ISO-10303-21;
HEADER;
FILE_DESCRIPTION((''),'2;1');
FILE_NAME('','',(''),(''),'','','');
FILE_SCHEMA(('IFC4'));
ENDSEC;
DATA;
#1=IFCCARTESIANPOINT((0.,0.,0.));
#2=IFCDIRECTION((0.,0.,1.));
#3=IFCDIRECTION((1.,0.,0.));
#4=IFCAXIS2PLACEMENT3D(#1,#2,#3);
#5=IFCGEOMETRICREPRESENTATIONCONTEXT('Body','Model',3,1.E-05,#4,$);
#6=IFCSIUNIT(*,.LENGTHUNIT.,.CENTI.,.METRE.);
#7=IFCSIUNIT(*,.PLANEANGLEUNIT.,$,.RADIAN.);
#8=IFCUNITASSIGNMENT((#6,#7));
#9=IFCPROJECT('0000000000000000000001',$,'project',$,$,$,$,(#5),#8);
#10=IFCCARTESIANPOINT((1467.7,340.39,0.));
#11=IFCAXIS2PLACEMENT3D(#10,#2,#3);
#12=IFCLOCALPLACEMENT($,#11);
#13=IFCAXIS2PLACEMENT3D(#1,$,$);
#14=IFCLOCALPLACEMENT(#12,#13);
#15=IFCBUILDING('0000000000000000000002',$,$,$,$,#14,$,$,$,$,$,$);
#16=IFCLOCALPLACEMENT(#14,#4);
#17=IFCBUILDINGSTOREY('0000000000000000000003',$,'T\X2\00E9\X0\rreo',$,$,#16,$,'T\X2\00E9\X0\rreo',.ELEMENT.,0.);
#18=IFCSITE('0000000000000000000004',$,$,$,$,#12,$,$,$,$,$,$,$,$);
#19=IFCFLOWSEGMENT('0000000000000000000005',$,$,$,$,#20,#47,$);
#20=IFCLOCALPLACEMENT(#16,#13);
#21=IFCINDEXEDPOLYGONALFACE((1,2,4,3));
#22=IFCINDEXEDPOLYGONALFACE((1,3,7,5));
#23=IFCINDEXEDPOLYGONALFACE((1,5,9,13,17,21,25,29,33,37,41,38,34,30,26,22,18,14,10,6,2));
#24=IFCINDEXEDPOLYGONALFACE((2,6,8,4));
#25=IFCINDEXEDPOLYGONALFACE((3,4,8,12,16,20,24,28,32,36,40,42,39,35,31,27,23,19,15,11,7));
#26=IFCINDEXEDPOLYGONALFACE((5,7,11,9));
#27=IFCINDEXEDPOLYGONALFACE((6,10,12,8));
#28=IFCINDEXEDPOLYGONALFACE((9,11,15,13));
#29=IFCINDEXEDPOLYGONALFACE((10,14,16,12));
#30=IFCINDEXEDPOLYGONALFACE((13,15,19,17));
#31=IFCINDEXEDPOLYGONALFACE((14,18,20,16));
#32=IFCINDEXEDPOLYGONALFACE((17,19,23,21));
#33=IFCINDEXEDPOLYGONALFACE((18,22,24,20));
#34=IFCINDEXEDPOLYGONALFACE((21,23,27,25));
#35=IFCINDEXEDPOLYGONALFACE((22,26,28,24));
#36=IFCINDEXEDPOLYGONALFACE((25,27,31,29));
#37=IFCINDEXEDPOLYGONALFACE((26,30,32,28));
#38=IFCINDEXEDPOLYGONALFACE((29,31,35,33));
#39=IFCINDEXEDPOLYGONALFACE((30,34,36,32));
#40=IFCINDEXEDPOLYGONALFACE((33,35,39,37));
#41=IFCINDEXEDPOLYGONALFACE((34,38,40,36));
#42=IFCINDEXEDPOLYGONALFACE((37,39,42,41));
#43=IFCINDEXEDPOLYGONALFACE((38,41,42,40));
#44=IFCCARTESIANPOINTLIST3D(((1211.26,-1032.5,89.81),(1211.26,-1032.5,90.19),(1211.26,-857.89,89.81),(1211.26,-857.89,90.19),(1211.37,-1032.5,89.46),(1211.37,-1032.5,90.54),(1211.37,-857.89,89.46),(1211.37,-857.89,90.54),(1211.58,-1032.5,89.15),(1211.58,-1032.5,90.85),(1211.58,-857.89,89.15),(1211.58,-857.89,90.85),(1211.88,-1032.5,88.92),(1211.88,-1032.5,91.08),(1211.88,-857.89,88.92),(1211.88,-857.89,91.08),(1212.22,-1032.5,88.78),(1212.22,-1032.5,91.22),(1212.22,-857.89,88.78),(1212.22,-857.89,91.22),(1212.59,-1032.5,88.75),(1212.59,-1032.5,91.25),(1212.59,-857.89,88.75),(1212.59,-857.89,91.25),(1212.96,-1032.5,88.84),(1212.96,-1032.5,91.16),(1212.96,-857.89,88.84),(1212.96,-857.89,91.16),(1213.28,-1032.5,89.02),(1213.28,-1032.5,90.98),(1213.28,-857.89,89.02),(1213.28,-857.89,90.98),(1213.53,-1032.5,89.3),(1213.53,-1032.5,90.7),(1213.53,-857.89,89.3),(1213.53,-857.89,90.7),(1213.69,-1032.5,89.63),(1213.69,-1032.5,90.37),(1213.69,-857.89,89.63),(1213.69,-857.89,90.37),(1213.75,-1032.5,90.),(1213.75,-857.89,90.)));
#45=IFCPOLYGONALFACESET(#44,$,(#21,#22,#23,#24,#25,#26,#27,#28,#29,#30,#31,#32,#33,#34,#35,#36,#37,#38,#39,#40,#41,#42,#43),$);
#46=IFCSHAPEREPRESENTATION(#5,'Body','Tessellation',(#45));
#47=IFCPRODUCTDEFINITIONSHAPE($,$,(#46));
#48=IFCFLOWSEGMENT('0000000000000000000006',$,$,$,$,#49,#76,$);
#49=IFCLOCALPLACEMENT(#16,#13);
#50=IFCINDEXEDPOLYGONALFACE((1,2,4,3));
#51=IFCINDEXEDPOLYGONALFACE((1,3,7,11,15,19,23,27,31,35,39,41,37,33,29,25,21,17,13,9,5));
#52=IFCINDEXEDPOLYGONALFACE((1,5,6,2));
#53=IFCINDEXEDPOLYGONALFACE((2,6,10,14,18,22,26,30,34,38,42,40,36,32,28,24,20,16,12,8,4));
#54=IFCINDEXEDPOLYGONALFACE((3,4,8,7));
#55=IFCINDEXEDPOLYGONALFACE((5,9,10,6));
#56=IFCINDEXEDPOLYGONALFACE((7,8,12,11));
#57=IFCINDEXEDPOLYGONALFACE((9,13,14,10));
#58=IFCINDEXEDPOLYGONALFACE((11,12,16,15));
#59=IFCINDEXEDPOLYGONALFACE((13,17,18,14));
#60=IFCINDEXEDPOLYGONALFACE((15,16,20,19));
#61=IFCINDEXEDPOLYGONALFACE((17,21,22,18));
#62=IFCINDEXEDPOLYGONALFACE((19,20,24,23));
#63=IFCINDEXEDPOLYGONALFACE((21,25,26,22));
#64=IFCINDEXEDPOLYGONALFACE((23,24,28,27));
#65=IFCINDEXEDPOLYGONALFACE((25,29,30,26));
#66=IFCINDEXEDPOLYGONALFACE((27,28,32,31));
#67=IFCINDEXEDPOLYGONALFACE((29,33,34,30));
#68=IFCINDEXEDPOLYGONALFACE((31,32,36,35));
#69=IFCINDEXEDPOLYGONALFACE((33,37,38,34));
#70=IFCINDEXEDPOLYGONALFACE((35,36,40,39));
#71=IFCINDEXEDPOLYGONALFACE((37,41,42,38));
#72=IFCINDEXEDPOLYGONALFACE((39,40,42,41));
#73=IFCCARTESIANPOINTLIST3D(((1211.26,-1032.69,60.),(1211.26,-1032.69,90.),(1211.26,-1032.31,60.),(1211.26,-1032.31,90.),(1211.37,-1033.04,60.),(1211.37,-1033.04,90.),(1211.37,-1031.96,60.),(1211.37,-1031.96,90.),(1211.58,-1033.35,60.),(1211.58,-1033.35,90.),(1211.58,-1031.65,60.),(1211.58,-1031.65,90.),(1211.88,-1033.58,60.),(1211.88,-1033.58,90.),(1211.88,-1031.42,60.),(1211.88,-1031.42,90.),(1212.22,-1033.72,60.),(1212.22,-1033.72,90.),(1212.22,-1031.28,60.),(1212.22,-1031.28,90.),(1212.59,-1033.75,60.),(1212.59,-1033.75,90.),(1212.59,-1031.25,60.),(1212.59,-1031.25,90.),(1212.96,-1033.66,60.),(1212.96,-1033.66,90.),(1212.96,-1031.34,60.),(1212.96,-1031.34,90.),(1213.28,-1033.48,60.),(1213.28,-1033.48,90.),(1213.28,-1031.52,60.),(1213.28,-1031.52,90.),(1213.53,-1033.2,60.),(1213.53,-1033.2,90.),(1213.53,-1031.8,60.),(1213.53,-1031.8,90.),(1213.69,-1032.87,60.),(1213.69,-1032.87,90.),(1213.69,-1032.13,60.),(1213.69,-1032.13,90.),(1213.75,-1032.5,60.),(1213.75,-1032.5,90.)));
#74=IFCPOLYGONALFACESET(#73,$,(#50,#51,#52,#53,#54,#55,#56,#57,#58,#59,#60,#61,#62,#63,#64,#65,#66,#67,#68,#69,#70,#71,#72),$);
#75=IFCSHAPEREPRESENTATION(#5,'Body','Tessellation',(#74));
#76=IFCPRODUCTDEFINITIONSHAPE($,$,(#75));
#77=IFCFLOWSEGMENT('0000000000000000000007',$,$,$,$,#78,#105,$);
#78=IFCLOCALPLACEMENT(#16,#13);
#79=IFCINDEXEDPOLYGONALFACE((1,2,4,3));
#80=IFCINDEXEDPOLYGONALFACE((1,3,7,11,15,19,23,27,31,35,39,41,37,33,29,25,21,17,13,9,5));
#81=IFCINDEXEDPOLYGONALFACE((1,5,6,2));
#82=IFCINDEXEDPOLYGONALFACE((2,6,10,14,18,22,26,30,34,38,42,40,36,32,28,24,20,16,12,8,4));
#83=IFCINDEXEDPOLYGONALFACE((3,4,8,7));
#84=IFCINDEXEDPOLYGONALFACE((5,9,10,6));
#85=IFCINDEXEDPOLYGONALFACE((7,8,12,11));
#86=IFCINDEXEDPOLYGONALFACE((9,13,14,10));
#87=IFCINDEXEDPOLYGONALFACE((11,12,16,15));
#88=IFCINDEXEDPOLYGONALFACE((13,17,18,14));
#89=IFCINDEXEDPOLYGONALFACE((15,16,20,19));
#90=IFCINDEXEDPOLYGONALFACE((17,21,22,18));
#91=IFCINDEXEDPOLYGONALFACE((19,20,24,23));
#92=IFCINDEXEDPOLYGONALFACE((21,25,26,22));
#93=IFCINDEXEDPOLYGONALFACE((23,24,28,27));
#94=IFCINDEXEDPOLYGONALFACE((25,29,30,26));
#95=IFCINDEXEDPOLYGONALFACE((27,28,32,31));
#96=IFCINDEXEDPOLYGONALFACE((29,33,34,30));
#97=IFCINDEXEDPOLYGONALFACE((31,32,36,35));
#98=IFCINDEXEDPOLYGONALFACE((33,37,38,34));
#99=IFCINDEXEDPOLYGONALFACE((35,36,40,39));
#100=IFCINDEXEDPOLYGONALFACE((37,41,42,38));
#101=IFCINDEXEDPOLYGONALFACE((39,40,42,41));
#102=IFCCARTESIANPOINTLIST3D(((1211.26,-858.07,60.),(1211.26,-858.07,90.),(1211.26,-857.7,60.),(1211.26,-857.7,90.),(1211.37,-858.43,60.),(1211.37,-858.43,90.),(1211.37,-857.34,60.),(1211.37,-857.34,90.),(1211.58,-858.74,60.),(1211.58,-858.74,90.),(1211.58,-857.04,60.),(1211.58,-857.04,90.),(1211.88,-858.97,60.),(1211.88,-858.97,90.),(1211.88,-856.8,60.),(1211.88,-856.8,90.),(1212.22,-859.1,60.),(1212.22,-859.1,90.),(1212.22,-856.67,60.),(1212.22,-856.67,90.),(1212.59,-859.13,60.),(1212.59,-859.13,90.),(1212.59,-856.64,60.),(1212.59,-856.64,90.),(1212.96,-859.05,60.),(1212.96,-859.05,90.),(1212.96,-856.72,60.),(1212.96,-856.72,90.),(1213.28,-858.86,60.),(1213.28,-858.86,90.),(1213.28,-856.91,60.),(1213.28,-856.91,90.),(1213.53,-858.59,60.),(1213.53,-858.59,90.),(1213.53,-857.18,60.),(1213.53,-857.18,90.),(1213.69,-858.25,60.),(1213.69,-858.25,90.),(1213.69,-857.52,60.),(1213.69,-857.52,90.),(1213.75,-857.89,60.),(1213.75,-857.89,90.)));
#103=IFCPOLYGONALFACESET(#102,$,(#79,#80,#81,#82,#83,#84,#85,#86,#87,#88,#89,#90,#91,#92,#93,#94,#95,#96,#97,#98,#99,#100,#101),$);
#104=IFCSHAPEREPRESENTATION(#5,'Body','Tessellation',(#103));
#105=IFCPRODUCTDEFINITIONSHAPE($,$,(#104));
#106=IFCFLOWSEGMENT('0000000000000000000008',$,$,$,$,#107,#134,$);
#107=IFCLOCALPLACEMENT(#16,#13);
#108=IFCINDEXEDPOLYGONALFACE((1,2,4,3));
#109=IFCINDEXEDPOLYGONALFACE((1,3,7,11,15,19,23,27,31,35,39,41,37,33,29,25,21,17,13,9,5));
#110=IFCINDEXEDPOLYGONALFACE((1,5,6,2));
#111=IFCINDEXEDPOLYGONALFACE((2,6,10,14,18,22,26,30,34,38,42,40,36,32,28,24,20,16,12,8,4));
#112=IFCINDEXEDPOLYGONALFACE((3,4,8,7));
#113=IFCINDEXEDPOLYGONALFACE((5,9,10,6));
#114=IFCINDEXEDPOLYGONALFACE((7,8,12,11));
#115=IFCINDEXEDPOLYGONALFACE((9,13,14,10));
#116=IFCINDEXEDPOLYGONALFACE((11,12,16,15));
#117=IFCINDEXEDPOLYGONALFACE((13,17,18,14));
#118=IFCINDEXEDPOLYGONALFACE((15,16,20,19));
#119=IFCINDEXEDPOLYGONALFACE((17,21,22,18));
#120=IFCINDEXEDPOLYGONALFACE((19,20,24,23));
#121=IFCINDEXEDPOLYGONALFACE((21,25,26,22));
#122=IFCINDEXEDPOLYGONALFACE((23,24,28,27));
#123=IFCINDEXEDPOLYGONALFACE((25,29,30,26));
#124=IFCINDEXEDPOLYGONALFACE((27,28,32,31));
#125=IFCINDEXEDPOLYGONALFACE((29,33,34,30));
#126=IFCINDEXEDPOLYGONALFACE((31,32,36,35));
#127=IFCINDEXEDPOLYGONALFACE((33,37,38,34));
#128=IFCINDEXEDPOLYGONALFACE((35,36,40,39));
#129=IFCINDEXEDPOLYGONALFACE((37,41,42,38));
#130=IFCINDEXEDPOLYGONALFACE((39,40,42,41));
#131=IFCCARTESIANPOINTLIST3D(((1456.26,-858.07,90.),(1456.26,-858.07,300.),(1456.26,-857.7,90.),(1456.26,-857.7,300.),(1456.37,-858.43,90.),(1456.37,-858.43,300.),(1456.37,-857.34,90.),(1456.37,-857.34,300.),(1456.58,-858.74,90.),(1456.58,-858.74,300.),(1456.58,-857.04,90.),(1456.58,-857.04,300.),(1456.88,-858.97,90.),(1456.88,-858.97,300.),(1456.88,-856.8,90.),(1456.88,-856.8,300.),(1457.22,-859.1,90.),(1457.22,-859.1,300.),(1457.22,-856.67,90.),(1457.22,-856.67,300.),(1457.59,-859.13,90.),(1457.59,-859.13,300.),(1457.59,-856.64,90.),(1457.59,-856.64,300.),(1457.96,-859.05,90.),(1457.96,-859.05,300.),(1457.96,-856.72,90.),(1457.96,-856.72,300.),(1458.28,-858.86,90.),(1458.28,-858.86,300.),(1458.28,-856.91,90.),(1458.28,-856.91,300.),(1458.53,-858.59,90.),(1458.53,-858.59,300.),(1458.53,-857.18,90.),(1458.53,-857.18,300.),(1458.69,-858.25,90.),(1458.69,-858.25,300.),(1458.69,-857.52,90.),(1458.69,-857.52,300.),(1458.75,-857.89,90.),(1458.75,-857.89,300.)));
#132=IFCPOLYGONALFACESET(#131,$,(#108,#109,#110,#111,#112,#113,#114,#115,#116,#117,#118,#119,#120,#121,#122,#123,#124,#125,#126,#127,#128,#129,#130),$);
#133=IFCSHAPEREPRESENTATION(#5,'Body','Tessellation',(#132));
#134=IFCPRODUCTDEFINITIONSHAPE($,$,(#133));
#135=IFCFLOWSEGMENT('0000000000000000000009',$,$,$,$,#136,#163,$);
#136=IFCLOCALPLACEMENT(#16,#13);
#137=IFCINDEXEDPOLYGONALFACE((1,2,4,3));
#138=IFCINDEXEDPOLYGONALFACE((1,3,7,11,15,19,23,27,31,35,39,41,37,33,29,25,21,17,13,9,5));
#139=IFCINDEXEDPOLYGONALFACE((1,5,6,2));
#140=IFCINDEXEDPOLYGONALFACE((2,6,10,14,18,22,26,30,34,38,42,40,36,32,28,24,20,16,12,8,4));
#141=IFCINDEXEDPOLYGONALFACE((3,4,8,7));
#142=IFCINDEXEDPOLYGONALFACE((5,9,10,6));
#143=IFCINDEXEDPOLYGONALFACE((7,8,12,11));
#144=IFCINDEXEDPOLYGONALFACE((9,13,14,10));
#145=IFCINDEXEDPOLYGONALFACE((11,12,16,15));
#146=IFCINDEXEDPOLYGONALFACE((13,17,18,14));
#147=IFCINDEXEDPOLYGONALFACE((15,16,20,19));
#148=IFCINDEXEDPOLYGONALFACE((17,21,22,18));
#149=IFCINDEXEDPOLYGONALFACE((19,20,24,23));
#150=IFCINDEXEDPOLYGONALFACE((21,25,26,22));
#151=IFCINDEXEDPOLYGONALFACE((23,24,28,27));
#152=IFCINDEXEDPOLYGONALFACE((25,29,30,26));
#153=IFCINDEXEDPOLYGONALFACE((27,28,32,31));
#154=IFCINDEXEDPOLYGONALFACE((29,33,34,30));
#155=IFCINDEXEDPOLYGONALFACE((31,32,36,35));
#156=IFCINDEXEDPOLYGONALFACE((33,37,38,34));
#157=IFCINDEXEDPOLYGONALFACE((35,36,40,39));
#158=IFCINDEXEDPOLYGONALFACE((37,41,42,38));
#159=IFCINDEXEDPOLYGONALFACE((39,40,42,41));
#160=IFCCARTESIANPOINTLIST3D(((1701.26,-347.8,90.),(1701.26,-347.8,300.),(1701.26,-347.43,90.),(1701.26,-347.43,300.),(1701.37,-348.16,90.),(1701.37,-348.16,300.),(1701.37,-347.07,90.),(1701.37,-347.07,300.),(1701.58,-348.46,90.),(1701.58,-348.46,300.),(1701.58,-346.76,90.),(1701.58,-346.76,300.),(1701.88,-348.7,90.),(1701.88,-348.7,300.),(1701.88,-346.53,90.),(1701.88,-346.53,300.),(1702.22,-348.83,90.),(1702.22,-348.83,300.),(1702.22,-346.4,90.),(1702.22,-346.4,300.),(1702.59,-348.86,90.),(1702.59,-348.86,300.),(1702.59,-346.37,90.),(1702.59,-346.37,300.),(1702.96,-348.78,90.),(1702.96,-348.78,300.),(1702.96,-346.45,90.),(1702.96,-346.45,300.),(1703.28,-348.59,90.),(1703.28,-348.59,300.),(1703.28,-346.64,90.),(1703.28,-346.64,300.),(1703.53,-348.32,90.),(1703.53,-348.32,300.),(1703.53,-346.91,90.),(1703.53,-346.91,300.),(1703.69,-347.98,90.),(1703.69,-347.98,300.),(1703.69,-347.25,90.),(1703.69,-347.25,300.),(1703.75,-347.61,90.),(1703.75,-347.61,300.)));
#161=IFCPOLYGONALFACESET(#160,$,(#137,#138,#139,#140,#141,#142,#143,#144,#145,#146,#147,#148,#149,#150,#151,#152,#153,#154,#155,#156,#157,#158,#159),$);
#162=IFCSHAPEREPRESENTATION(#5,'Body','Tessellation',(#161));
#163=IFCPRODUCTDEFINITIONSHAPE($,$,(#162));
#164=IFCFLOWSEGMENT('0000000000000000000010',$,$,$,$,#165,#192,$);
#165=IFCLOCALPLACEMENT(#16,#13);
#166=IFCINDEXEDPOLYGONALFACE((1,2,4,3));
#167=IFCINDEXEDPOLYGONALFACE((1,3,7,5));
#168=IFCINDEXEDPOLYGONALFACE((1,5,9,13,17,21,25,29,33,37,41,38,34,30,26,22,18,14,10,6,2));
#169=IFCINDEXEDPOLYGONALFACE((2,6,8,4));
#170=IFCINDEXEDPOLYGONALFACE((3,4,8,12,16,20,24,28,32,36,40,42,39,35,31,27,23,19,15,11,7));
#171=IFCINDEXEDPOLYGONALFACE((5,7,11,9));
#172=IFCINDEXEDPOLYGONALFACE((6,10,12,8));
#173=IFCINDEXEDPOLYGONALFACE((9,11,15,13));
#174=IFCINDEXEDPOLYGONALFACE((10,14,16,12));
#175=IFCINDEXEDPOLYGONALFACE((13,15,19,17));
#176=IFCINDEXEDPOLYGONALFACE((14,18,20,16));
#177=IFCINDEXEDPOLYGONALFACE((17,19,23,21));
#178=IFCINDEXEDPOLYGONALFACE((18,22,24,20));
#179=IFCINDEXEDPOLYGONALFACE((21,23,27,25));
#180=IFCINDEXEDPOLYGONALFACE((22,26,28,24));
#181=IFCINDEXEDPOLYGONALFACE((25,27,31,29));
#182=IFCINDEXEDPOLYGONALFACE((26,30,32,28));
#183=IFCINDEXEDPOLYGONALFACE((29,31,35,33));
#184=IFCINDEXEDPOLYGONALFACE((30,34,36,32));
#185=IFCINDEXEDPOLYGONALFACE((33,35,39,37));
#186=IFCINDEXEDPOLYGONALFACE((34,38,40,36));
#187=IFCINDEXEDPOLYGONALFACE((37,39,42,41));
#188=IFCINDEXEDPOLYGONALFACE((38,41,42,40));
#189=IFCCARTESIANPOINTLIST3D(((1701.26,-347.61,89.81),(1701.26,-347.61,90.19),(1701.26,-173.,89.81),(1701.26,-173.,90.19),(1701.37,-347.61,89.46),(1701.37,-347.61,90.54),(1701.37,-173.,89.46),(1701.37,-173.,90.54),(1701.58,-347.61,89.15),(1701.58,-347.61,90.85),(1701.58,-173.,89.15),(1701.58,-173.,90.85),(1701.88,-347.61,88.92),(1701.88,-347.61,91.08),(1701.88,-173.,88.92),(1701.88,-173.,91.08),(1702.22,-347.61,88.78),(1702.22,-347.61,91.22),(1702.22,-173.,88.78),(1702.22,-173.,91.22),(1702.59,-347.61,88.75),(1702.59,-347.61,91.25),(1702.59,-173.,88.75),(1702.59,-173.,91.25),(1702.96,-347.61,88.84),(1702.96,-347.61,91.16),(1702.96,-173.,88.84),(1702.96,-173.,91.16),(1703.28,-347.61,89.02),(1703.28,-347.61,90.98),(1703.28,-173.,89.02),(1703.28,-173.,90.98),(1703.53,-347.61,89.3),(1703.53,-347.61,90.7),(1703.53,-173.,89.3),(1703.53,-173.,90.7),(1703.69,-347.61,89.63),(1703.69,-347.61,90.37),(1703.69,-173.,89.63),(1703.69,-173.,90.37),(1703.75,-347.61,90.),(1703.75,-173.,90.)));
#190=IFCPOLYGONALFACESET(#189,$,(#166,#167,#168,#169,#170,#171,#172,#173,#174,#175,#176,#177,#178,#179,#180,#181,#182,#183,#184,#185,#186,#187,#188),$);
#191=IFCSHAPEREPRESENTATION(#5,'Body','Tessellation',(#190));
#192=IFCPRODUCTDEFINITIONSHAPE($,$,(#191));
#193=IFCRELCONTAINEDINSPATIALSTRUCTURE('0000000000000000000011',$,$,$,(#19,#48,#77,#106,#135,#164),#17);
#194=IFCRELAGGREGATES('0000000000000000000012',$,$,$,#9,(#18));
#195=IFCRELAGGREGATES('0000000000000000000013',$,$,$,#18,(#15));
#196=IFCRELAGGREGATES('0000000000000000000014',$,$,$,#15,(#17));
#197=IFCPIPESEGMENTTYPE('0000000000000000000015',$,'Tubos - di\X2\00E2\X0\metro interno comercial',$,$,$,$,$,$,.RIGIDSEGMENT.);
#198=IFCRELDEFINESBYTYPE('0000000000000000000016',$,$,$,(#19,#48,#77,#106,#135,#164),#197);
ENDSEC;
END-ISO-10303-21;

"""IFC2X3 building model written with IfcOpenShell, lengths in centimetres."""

from ifc_helpers import new_model, si_unit, frame, origin, origin_with_axes, origin_2d_with_axis, place, context, project, spatial, circle, extrude, type_object, element, save


model = new_model("IFC2X3")

# Units and contexts
model_context = context("Model", 3, precision=1e-05, world=origin_with_axes(), identifier="Body")
ifc_project = project(units=[si_unit("LENGTHUNIT", "METRE", prefix="CENTI"), si_unit("PLANEANGLEUNIT", "RADIAN")], contexts=[model_context])

# Site, building, storey
site_placement = place(None, frame((1467.7, 340.39, 0.0), z_axis=(0.0, 0.0, 1.0), x_axis=(1.0, 0.0, 0.0)))
site = spatial("IfcSite", under=ifc_project, at=site_placement)
building_placement = place(site_placement, origin())
building = spatial("IfcBuilding", under=site, at=building_placement)
storey_placement = place(building_placement, origin_with_axes())
storey = spatial("IfcBuildingStorey", under=building, at=storey_placement, Name="Térreo", LongName="Térreo", CompositionType="ELEMENT", Elevation=0.0)

# Flow segments
pipe_segment_type = type_object("IfcPipeSegmentType", Name="Tubos - diâmetro interno comercial", PredefinedType="RIGIDSEGMENT")
flow_segment_1_placement = place(storey_placement, frame((1212.5, -945.19, 91.25), z_axis=(0.0, 0.0, 1.0), x_axis=(1.0, 0.0, 0.0)))
element("IfcFlowSegment", 1, at=flow_segment_1_placement, inside=storey, type_object=pipe_segment_type, context=model_context, shape_type="SolidModel", body=[
    extrude(circle(Radius=1.25, at=origin_2d_with_axis()), frame((0.0, 87.31, -1.25), z_axis=(0.0, -1.0, 0.0), x_axis=(1.0, 0.0, 0.0)), (0.0, 0.0, 1.0), 174.61),
])
for number, where, z_axis, x_axis in (
    (2, (1212.5, -1032.5, 90.0), (0.0, 0.0, 1.0), (1.0, 0.0, 0.0)),
    (3, (1212.5, -857.89, 90.0), (0.0, 0.0, 1.0), (1.0, 0.0, 0.0)),
):
    element("IfcFlowSegment", number, at=place(storey_placement, frame(where, z_axis=z_axis, x_axis=x_axis)), inside=storey, type_object=pipe_segment_type, context=model_context, shape_type="SolidModel", body=[
        extrude(circle(Radius=1.25, at=origin_2d_with_axis()), frame((0.0, 0.0, 0.0), z_axis=(0.0, 0.0, -1.0), x_axis=(1.0, 0.0, 0.0)), (0.0, 0.0, 1.0), 30.0),
    ])
for number, where, z_axis, x_axis in (
    (4, (1457.5, -857.89, 300.0), (0.0, 0.0, 1.0), (1.0, 0.0, 0.0)),
    (5, (1702.5, -347.61, 300.0), (0.0, 0.0, 1.0), (1.0, 0.0, 0.0)),
):
    element("IfcFlowSegment", number, at=place(storey_placement, frame(where, z_axis=z_axis, x_axis=x_axis)), inside=storey, type_object=pipe_segment_type, context=model_context, shape_type="SolidModel", body=[
        extrude(circle(Radius=1.25, at=origin_2d_with_axis()), frame((0.0, 0.0, 0.0), z_axis=(0.0, 0.0, -1.0), x_axis=(1.0, 0.0, 0.0)), (0.0, 0.0, 1.0), 210.0),
    ])
flow_segment_2_placement = place(storey_placement, frame((1702.5, -260.31, 91.25), z_axis=(0.0, 0.0, 1.0), x_axis=(1.0, 0.0, 0.0)))
element("IfcFlowSegment", 6, at=flow_segment_2_placement, inside=storey, type_object=pipe_segment_type, context=model_context, shape_type="SolidModel", body=[
    extrude(circle(Radius=1.25, at=origin_2d_with_axis()), frame((0.0, -87.31, -1.25), z_axis=(0.0, 1.0, 0.0), x_axis=(1.0, 0.0, 0.0)), (0.0, 0.0, 1.0), 174.61),
])

save(model, "model.ifc")
